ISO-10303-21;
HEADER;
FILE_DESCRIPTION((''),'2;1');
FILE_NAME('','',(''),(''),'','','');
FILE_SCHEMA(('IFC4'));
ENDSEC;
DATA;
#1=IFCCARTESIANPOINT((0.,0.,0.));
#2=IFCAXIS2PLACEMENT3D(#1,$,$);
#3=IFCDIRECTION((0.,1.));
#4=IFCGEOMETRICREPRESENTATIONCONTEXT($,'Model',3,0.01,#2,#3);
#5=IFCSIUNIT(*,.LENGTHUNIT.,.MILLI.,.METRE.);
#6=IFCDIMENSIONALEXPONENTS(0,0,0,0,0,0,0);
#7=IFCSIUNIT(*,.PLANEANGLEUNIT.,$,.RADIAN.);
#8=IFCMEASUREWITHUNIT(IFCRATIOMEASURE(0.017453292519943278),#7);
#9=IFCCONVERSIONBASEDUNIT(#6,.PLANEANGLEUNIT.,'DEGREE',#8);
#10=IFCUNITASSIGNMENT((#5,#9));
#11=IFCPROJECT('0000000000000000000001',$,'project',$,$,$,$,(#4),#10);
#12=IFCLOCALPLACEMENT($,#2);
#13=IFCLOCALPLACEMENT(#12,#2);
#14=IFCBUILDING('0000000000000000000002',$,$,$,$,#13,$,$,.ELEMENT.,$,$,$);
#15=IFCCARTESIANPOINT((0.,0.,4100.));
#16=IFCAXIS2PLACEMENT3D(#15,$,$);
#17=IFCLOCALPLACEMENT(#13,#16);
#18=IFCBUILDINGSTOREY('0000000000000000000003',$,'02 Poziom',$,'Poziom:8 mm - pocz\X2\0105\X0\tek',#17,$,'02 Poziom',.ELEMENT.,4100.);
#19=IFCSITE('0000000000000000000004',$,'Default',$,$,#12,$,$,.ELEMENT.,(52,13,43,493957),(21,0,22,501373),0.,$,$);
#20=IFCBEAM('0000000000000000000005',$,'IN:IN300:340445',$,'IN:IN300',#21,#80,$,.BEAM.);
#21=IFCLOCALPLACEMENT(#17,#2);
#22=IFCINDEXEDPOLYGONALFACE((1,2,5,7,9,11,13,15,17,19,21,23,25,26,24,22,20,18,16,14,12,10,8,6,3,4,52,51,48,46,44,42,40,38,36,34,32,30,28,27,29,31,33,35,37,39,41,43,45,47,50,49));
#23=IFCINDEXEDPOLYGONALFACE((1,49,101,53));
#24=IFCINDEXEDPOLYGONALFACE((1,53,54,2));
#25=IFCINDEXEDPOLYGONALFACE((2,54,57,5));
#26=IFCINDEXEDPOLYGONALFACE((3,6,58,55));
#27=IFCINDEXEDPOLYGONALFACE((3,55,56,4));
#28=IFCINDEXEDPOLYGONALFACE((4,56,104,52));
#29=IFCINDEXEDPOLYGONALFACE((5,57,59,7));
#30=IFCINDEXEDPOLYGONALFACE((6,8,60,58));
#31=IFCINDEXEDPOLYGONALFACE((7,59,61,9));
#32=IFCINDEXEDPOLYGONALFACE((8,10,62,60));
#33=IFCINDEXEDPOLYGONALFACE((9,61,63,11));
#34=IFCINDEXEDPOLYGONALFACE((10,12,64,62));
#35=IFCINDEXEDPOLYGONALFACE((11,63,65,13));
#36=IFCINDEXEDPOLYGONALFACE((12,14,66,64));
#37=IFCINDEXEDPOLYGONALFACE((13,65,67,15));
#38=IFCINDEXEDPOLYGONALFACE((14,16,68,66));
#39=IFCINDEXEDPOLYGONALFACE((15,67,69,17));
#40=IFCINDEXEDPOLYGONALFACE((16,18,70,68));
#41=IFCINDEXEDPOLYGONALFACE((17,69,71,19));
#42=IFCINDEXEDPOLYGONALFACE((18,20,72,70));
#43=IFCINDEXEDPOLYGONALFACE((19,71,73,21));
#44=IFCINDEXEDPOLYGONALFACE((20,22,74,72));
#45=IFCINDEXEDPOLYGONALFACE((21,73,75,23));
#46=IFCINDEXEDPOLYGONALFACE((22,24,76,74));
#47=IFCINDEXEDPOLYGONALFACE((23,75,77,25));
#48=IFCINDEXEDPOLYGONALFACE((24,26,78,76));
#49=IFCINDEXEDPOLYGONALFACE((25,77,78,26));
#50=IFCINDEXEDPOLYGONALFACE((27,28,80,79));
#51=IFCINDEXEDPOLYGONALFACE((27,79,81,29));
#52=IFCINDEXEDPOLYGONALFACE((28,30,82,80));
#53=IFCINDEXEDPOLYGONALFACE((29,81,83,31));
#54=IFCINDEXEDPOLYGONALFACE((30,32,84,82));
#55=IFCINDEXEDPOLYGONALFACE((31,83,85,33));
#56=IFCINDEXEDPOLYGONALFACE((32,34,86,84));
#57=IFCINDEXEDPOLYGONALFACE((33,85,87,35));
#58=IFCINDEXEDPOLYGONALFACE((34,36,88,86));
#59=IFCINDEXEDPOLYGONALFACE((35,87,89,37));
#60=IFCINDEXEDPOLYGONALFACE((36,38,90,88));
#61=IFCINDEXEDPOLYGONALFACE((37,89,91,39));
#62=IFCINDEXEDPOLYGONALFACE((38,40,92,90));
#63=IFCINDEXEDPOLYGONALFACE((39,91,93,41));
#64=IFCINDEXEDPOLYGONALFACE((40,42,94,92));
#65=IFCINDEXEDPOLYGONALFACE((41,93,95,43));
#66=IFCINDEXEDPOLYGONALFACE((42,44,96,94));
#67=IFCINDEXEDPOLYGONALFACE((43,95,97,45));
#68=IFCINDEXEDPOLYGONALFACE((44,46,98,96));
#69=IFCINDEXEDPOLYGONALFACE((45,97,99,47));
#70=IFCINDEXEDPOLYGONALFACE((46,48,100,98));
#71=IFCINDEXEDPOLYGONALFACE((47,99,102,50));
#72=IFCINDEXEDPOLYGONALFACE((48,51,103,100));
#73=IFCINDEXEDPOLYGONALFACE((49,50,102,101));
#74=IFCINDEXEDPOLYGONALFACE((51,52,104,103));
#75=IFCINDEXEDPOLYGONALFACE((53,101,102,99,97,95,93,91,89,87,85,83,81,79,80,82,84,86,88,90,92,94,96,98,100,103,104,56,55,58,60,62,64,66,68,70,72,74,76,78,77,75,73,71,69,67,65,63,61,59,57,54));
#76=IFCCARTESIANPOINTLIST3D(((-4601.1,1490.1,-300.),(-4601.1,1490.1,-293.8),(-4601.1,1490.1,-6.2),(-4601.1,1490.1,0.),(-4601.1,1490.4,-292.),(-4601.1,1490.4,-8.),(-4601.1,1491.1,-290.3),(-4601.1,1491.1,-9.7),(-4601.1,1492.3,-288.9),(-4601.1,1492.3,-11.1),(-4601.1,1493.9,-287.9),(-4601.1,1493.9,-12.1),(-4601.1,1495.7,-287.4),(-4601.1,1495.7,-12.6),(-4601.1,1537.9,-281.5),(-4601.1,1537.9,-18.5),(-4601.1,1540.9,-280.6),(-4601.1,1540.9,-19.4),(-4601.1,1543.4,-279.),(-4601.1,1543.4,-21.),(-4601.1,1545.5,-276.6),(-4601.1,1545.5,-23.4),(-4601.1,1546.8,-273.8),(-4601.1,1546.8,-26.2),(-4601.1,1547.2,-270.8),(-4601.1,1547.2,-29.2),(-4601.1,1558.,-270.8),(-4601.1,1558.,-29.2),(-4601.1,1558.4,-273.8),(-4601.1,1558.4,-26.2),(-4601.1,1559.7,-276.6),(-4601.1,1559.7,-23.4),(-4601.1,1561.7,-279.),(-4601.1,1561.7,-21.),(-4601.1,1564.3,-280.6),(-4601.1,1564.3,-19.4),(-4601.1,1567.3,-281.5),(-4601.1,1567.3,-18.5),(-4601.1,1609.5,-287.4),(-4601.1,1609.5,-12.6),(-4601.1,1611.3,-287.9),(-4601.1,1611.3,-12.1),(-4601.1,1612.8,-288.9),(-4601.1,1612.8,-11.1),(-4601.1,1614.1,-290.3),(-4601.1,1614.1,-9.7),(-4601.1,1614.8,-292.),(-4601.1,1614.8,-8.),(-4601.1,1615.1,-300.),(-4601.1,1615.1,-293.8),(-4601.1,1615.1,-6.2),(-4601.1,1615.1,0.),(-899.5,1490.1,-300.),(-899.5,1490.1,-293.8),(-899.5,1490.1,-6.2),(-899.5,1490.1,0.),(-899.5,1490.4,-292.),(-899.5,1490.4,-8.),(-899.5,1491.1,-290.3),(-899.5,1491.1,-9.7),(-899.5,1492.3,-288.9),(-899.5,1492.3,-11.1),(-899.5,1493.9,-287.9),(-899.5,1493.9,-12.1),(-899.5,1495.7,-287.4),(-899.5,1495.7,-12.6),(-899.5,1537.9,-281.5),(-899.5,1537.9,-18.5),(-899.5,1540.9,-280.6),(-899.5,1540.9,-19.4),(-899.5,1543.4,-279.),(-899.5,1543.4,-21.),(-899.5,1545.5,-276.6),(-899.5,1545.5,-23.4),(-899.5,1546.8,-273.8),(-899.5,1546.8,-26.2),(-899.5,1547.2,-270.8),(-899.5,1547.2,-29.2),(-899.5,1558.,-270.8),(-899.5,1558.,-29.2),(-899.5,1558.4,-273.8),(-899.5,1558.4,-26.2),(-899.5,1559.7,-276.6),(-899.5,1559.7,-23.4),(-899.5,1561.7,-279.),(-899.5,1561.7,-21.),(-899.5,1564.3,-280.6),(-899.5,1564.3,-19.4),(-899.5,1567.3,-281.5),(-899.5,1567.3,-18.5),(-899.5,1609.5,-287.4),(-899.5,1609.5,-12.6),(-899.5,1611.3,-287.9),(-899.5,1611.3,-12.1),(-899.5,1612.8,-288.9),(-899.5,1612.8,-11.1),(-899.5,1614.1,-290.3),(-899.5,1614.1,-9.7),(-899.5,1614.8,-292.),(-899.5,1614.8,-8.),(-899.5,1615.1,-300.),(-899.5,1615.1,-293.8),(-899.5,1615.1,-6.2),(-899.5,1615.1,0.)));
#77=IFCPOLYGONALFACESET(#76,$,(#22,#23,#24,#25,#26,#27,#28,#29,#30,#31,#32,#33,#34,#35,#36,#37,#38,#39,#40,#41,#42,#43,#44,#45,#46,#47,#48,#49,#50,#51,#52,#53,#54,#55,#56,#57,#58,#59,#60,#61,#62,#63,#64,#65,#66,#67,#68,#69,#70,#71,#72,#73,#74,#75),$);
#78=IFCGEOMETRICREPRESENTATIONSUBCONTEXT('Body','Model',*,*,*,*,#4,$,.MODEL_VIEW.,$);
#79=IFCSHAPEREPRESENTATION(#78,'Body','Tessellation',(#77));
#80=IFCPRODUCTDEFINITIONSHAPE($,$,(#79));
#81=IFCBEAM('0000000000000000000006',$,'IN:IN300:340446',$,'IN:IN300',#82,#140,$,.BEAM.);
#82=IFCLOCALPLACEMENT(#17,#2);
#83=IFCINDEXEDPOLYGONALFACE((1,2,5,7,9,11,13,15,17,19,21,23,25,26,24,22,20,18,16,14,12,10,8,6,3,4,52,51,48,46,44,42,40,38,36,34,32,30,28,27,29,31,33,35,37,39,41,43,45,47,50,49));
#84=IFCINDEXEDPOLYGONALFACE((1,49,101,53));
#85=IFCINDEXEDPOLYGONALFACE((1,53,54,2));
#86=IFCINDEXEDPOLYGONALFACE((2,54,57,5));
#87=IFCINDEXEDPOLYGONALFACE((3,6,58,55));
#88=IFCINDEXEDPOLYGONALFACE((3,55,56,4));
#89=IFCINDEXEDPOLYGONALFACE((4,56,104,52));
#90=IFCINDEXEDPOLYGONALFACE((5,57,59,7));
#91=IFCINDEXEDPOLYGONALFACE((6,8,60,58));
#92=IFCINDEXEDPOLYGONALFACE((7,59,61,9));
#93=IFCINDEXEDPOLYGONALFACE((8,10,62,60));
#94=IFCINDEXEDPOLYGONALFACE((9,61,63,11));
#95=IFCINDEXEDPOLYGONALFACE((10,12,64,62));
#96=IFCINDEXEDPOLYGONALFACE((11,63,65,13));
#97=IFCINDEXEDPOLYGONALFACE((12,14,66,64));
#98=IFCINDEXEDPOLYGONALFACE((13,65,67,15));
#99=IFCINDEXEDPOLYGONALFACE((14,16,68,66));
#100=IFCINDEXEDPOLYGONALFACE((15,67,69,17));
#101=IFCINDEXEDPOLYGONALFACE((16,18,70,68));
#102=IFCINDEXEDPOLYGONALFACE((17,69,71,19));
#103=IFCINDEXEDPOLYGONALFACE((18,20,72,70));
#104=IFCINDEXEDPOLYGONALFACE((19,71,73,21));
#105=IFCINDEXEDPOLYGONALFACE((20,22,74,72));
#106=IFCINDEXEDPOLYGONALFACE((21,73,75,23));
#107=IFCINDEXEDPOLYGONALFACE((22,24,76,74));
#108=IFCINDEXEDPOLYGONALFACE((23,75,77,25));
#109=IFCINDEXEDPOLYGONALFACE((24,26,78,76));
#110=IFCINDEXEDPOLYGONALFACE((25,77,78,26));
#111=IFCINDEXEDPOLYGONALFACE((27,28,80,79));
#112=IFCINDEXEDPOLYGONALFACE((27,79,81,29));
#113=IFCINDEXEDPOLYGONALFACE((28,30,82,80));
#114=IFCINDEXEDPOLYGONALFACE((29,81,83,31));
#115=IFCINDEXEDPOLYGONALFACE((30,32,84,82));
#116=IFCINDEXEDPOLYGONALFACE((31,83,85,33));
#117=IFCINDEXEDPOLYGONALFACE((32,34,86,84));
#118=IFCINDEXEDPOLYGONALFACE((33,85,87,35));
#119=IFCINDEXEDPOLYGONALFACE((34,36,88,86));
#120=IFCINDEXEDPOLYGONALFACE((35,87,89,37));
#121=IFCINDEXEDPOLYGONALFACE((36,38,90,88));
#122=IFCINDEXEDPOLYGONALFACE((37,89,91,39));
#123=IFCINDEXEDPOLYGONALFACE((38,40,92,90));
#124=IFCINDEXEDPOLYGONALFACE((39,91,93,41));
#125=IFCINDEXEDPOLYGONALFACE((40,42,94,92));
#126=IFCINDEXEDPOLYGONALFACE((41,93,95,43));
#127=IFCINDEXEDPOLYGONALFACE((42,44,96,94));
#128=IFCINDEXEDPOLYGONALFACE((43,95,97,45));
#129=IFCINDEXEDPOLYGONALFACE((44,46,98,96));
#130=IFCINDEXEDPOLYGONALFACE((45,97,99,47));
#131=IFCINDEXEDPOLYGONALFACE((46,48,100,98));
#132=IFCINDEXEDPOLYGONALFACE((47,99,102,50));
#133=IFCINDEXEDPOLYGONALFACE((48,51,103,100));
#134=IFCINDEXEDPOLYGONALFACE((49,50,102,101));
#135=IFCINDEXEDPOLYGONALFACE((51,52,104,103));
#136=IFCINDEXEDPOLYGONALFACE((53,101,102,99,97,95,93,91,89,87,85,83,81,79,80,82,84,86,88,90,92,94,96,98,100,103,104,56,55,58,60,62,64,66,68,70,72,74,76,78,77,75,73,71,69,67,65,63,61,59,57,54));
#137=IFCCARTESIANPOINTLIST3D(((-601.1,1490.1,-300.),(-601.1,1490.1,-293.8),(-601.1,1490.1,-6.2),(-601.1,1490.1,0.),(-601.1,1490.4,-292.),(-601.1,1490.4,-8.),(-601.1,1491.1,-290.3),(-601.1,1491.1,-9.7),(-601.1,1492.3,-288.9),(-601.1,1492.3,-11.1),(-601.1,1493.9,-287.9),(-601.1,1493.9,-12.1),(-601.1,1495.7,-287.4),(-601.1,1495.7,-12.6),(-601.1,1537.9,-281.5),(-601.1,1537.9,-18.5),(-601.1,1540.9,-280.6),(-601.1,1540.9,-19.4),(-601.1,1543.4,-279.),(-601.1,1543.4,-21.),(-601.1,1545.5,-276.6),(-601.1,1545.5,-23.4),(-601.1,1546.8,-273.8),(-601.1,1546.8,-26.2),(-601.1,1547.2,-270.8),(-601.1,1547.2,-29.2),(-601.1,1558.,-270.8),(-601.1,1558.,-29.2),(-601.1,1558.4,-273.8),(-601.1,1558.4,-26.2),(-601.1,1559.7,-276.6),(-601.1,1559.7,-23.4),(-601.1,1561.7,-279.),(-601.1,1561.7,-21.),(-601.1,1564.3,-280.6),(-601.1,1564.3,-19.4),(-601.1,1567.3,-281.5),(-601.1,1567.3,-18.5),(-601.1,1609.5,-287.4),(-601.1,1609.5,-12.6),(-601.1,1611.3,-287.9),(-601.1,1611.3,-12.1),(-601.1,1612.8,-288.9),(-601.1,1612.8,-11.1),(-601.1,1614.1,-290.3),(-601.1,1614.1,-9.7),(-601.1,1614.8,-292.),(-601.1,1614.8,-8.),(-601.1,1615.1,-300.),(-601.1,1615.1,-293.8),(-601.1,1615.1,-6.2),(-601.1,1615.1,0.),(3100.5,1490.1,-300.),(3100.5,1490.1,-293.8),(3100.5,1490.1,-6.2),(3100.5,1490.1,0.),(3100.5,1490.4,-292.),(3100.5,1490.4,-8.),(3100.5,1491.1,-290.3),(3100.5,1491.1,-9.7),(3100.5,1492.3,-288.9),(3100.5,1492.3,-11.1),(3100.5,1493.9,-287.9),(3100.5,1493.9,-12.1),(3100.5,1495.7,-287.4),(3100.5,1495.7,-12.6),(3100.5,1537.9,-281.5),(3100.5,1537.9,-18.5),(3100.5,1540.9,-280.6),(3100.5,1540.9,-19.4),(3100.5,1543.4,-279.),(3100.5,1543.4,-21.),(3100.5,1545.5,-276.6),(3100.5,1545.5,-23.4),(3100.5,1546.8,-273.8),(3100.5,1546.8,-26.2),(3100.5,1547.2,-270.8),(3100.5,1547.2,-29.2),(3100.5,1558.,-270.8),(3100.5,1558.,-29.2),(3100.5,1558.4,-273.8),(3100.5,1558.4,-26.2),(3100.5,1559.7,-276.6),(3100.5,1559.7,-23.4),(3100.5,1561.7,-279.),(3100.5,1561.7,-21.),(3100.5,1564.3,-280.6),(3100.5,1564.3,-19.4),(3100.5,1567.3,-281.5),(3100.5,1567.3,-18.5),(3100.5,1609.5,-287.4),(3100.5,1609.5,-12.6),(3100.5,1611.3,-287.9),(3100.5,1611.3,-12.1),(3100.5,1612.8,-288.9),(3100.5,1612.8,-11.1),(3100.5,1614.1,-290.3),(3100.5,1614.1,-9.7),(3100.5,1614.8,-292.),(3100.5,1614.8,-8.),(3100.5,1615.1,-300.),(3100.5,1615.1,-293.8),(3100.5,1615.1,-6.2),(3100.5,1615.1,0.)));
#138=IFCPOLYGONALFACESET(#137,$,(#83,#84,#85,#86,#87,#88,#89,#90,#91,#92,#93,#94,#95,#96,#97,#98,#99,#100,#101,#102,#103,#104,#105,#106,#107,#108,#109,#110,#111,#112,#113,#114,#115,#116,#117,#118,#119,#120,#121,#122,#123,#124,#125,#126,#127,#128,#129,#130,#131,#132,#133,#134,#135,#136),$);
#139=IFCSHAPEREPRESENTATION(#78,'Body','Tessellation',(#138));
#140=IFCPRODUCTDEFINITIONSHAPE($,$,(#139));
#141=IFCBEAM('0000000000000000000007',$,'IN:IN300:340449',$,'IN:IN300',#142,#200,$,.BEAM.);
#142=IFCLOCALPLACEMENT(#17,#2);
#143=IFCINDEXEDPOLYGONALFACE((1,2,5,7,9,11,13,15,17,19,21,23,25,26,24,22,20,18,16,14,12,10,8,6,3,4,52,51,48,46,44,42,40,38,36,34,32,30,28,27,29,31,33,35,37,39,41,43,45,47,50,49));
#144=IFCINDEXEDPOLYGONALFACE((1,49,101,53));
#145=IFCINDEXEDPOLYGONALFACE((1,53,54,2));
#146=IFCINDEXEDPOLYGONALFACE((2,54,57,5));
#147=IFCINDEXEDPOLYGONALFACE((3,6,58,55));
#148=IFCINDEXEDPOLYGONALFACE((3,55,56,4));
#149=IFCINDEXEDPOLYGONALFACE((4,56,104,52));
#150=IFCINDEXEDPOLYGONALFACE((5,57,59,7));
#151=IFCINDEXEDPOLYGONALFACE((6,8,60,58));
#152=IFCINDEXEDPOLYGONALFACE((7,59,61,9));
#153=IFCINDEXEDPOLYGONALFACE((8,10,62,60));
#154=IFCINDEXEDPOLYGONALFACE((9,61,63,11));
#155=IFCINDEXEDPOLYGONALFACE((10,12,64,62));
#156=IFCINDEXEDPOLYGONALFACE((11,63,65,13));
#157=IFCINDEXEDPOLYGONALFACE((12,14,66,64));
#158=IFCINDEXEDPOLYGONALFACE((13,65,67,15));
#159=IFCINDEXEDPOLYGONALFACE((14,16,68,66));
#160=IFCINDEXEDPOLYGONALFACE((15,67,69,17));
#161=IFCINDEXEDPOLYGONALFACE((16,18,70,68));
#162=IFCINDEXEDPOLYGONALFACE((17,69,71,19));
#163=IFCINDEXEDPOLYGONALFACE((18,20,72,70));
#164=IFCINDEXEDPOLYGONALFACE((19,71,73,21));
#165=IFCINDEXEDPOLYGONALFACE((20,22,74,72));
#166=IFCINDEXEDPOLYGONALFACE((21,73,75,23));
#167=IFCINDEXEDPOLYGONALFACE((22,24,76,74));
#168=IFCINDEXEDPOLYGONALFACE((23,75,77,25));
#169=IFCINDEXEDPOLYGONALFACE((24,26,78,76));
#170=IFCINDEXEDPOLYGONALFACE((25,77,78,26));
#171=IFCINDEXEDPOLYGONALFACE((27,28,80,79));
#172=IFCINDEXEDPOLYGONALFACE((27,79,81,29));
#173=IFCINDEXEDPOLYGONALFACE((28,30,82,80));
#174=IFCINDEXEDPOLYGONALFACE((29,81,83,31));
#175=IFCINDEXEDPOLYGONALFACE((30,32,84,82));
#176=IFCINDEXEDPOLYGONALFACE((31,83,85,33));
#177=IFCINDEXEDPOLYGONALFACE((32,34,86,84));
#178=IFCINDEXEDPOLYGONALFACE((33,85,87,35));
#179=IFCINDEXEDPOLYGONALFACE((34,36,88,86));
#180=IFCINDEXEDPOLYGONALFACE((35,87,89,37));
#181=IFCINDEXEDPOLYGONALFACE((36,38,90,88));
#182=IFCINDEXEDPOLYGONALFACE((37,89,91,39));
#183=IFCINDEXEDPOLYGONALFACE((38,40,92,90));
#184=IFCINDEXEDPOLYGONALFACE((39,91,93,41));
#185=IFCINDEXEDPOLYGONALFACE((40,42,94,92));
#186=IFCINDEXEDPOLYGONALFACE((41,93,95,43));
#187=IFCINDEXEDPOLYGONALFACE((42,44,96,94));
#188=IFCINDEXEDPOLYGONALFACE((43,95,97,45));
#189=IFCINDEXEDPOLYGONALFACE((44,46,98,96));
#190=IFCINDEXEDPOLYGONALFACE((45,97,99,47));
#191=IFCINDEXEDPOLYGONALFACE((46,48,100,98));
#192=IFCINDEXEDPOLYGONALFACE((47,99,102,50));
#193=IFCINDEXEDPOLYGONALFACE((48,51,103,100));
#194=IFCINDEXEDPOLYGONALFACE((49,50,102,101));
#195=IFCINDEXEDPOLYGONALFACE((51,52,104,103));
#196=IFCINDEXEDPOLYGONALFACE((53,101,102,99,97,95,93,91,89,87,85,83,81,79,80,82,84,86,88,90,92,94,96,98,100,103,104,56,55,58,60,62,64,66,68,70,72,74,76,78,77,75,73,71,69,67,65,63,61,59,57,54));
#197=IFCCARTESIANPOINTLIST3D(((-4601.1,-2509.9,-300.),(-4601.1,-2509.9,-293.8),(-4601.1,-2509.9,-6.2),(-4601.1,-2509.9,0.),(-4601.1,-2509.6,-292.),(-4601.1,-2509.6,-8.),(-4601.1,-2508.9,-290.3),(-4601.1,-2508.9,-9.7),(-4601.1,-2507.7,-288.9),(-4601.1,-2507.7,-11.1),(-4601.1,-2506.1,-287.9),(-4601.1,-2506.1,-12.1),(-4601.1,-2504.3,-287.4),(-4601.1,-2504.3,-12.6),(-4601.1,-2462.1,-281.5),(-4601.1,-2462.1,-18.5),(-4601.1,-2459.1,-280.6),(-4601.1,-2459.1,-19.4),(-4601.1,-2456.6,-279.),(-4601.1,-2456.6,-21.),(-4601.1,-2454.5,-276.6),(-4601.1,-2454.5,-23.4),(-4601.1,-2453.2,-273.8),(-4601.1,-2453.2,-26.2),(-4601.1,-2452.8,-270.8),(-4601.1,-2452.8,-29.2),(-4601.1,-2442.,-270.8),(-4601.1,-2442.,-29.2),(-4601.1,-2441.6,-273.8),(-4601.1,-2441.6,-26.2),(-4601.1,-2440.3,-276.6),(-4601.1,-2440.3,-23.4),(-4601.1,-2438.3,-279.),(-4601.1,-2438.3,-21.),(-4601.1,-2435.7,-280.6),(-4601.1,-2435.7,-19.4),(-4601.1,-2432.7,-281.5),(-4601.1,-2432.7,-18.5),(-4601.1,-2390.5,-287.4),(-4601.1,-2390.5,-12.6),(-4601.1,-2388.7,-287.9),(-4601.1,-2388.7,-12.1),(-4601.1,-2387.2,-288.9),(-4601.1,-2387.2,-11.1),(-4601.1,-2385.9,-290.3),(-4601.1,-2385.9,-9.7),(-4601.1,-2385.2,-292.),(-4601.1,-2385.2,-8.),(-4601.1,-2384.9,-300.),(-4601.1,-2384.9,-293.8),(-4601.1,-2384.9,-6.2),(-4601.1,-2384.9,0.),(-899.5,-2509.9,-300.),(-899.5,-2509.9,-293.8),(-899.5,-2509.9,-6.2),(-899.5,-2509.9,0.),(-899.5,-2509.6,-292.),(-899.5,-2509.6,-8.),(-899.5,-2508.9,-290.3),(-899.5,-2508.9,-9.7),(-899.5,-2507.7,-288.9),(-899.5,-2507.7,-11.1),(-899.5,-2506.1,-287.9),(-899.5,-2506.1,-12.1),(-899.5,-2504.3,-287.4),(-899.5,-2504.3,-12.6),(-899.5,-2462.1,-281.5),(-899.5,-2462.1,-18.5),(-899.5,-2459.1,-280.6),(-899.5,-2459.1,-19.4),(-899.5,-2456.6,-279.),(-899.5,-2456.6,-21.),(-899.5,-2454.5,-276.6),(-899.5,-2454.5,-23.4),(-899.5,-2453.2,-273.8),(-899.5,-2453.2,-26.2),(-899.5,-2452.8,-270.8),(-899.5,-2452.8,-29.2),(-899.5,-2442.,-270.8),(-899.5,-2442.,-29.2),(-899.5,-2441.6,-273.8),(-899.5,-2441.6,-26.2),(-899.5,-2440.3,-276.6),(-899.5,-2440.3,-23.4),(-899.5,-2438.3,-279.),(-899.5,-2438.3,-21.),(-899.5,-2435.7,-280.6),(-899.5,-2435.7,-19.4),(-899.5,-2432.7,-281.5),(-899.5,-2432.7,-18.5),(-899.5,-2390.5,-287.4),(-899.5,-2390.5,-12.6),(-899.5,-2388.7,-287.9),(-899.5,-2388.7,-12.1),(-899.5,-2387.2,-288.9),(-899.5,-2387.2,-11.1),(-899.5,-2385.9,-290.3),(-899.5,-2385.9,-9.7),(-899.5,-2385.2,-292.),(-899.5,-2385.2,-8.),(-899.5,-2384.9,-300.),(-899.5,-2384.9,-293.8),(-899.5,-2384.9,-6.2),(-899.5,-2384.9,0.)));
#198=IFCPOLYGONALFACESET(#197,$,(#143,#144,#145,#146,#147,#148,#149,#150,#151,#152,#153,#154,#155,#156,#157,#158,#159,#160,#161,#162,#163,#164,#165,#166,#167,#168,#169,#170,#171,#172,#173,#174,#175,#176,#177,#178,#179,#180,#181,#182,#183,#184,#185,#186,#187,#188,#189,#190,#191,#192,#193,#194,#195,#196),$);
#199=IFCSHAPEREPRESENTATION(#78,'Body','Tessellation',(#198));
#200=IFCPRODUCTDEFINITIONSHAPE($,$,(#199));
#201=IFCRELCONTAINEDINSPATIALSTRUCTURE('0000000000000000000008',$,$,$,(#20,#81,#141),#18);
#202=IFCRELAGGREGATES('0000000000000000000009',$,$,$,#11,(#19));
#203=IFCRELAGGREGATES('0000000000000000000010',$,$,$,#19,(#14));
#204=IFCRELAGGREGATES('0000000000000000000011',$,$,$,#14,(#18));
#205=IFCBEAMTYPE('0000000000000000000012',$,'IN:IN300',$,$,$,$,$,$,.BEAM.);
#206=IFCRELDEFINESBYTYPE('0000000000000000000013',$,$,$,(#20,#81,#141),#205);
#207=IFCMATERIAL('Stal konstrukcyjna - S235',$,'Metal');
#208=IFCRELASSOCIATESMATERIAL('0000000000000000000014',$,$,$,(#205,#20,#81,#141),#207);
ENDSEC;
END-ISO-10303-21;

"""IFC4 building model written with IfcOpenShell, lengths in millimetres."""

from ifc_helpers import new_model, entity, si_unit, converted_unit, direction, frame, origin, place, context, subcontext, project, spatial, line, arc, indexed_curve, outline, extrude, source, transform, mapped, material, type_object, type_shapes, element, save


model = new_model("IFC4")

# Units and contexts
model_context = context("Model", 3, precision=0.01, world=origin(), true_north=direction((0.0, 1.0)))
body_context = subcontext(model_context, "Body", "Model", "MODEL_VIEW")
ifc_project = project(units=[si_unit("LENGTHUNIT", "METRE", prefix="MILLI"), converted_unit("PLANEANGLEUNIT", "DEGREE", entity("IfcRatioMeasure", 0.017453292519943278), si_unit("PLANEANGLEUNIT", "RADIAN"), dimensions=[0, 0, 0, 0, 0, 0, 0])], contexts=[model_context])

# Site, building, storey
site_placement = place(None, origin())
site = spatial("IfcSite", under=ifc_project, at=site_placement, Name="Default", CompositionType="ELEMENT", RefLatitude=(52, 13, 43, 493957), RefLongitude=(21, 0, 22, 501373), RefElevation=0.0)
building_placement = place(site_placement, origin())
building = spatial("IfcBuilding", under=site, at=building_placement, CompositionType="ELEMENT")
storey_placement = place(building_placement, frame((0.0, 0.0, 4100.0)))
storey = spatial("IfcBuildingStorey", under=building, at=storey_placement, Name="02 Poziom", ObjectType="Poziom:8 mm - początek", LongName="02 Poziom", CompositionType="ELEMENT", Elevation=4100.0)

# Shared definitions
ifc_material_1 = material(Name="Stal konstrukcyjna - S235", Category="Metal")

# Beams
beam_type_1 = type_object("IfcBeamType", Name="IN:IN300", PredefinedType="BEAM", material=ifc_material_1)
shared_shape_1 = source(origin(), body_context, "Body", "SweptSolid", [
    extrude(outline(indexed_curve([(143.8, -62.5), (150.0, -62.5), (150.0, 62.5), (143.8, 62.5), (139.6, 60.9), (137.4, 56.9), (131.5, 14.7), (127.9, 8.1), (120.8, 5.4), (-120.8, 5.4), (-127.9, 8.1), (-131.5, 14.7), (-137.4, 56.9), (-139.6, 60.9), (-143.8, 62.5), (-150.0, 62.5), (-150.0, -62.5), (-143.8, -62.5), (-139.6, -60.9), (-137.4, -56.9), (-131.5, -14.7), (-127.9, -8.1), (-120.8, -5.4), (120.8, -5.4), (127.9, -8.1), (131.5, -14.7), (137.4, -56.9), (139.6, -60.9)], segments=[line(1, 2, 3, 4), arc(4, 5, 6), line(6, 7), arc(7, 8, 9), line(9, 10), arc(10, 11, 12), line(12, 13), arc(13, 14, 15), line(15, 16, 17, 18), arc(18, 19, 20), line(20, 21), arc(21, 22, 23), line(23, 24), arc(24, 25, 26), line(26, 27), arc(27, 28, 1)], self_intersect=False)), frame((-1850.8, 0.0, 0.0), z_axis=(1.0, 0.0, 0.0), x_axis=(0.0, 0.0, -1.0)), (0.0, 0.0, 1.0), 3701.6),
])
type_shapes(beam_type_1, [shared_shape_1])
for number, where, name in (
    (1, (-2750.3, 1552.6, -150.0), "IN:IN300:340445"),
    (2, (1249.7, 1552.6, -150.0), "IN:IN300:340446"),
    (3, (-2750.3, -2447.4, -150.0), "IN:IN300:340449"),
):
    element("IfcBeam", number, at=place(storey_placement, frame(where)), inside=storey, type_object=beam_type_1, material=ifc_material_1, Name=name, ObjectType="IN:IN300", PredefinedType="BEAM", context=body_context, shape_type="MappedRepresentation", body=[
        mapped(shared_shape_1, transform((0.0, 0.0, 0.0), scale=1.0)),
    ])

save(model, "model.ifc")
